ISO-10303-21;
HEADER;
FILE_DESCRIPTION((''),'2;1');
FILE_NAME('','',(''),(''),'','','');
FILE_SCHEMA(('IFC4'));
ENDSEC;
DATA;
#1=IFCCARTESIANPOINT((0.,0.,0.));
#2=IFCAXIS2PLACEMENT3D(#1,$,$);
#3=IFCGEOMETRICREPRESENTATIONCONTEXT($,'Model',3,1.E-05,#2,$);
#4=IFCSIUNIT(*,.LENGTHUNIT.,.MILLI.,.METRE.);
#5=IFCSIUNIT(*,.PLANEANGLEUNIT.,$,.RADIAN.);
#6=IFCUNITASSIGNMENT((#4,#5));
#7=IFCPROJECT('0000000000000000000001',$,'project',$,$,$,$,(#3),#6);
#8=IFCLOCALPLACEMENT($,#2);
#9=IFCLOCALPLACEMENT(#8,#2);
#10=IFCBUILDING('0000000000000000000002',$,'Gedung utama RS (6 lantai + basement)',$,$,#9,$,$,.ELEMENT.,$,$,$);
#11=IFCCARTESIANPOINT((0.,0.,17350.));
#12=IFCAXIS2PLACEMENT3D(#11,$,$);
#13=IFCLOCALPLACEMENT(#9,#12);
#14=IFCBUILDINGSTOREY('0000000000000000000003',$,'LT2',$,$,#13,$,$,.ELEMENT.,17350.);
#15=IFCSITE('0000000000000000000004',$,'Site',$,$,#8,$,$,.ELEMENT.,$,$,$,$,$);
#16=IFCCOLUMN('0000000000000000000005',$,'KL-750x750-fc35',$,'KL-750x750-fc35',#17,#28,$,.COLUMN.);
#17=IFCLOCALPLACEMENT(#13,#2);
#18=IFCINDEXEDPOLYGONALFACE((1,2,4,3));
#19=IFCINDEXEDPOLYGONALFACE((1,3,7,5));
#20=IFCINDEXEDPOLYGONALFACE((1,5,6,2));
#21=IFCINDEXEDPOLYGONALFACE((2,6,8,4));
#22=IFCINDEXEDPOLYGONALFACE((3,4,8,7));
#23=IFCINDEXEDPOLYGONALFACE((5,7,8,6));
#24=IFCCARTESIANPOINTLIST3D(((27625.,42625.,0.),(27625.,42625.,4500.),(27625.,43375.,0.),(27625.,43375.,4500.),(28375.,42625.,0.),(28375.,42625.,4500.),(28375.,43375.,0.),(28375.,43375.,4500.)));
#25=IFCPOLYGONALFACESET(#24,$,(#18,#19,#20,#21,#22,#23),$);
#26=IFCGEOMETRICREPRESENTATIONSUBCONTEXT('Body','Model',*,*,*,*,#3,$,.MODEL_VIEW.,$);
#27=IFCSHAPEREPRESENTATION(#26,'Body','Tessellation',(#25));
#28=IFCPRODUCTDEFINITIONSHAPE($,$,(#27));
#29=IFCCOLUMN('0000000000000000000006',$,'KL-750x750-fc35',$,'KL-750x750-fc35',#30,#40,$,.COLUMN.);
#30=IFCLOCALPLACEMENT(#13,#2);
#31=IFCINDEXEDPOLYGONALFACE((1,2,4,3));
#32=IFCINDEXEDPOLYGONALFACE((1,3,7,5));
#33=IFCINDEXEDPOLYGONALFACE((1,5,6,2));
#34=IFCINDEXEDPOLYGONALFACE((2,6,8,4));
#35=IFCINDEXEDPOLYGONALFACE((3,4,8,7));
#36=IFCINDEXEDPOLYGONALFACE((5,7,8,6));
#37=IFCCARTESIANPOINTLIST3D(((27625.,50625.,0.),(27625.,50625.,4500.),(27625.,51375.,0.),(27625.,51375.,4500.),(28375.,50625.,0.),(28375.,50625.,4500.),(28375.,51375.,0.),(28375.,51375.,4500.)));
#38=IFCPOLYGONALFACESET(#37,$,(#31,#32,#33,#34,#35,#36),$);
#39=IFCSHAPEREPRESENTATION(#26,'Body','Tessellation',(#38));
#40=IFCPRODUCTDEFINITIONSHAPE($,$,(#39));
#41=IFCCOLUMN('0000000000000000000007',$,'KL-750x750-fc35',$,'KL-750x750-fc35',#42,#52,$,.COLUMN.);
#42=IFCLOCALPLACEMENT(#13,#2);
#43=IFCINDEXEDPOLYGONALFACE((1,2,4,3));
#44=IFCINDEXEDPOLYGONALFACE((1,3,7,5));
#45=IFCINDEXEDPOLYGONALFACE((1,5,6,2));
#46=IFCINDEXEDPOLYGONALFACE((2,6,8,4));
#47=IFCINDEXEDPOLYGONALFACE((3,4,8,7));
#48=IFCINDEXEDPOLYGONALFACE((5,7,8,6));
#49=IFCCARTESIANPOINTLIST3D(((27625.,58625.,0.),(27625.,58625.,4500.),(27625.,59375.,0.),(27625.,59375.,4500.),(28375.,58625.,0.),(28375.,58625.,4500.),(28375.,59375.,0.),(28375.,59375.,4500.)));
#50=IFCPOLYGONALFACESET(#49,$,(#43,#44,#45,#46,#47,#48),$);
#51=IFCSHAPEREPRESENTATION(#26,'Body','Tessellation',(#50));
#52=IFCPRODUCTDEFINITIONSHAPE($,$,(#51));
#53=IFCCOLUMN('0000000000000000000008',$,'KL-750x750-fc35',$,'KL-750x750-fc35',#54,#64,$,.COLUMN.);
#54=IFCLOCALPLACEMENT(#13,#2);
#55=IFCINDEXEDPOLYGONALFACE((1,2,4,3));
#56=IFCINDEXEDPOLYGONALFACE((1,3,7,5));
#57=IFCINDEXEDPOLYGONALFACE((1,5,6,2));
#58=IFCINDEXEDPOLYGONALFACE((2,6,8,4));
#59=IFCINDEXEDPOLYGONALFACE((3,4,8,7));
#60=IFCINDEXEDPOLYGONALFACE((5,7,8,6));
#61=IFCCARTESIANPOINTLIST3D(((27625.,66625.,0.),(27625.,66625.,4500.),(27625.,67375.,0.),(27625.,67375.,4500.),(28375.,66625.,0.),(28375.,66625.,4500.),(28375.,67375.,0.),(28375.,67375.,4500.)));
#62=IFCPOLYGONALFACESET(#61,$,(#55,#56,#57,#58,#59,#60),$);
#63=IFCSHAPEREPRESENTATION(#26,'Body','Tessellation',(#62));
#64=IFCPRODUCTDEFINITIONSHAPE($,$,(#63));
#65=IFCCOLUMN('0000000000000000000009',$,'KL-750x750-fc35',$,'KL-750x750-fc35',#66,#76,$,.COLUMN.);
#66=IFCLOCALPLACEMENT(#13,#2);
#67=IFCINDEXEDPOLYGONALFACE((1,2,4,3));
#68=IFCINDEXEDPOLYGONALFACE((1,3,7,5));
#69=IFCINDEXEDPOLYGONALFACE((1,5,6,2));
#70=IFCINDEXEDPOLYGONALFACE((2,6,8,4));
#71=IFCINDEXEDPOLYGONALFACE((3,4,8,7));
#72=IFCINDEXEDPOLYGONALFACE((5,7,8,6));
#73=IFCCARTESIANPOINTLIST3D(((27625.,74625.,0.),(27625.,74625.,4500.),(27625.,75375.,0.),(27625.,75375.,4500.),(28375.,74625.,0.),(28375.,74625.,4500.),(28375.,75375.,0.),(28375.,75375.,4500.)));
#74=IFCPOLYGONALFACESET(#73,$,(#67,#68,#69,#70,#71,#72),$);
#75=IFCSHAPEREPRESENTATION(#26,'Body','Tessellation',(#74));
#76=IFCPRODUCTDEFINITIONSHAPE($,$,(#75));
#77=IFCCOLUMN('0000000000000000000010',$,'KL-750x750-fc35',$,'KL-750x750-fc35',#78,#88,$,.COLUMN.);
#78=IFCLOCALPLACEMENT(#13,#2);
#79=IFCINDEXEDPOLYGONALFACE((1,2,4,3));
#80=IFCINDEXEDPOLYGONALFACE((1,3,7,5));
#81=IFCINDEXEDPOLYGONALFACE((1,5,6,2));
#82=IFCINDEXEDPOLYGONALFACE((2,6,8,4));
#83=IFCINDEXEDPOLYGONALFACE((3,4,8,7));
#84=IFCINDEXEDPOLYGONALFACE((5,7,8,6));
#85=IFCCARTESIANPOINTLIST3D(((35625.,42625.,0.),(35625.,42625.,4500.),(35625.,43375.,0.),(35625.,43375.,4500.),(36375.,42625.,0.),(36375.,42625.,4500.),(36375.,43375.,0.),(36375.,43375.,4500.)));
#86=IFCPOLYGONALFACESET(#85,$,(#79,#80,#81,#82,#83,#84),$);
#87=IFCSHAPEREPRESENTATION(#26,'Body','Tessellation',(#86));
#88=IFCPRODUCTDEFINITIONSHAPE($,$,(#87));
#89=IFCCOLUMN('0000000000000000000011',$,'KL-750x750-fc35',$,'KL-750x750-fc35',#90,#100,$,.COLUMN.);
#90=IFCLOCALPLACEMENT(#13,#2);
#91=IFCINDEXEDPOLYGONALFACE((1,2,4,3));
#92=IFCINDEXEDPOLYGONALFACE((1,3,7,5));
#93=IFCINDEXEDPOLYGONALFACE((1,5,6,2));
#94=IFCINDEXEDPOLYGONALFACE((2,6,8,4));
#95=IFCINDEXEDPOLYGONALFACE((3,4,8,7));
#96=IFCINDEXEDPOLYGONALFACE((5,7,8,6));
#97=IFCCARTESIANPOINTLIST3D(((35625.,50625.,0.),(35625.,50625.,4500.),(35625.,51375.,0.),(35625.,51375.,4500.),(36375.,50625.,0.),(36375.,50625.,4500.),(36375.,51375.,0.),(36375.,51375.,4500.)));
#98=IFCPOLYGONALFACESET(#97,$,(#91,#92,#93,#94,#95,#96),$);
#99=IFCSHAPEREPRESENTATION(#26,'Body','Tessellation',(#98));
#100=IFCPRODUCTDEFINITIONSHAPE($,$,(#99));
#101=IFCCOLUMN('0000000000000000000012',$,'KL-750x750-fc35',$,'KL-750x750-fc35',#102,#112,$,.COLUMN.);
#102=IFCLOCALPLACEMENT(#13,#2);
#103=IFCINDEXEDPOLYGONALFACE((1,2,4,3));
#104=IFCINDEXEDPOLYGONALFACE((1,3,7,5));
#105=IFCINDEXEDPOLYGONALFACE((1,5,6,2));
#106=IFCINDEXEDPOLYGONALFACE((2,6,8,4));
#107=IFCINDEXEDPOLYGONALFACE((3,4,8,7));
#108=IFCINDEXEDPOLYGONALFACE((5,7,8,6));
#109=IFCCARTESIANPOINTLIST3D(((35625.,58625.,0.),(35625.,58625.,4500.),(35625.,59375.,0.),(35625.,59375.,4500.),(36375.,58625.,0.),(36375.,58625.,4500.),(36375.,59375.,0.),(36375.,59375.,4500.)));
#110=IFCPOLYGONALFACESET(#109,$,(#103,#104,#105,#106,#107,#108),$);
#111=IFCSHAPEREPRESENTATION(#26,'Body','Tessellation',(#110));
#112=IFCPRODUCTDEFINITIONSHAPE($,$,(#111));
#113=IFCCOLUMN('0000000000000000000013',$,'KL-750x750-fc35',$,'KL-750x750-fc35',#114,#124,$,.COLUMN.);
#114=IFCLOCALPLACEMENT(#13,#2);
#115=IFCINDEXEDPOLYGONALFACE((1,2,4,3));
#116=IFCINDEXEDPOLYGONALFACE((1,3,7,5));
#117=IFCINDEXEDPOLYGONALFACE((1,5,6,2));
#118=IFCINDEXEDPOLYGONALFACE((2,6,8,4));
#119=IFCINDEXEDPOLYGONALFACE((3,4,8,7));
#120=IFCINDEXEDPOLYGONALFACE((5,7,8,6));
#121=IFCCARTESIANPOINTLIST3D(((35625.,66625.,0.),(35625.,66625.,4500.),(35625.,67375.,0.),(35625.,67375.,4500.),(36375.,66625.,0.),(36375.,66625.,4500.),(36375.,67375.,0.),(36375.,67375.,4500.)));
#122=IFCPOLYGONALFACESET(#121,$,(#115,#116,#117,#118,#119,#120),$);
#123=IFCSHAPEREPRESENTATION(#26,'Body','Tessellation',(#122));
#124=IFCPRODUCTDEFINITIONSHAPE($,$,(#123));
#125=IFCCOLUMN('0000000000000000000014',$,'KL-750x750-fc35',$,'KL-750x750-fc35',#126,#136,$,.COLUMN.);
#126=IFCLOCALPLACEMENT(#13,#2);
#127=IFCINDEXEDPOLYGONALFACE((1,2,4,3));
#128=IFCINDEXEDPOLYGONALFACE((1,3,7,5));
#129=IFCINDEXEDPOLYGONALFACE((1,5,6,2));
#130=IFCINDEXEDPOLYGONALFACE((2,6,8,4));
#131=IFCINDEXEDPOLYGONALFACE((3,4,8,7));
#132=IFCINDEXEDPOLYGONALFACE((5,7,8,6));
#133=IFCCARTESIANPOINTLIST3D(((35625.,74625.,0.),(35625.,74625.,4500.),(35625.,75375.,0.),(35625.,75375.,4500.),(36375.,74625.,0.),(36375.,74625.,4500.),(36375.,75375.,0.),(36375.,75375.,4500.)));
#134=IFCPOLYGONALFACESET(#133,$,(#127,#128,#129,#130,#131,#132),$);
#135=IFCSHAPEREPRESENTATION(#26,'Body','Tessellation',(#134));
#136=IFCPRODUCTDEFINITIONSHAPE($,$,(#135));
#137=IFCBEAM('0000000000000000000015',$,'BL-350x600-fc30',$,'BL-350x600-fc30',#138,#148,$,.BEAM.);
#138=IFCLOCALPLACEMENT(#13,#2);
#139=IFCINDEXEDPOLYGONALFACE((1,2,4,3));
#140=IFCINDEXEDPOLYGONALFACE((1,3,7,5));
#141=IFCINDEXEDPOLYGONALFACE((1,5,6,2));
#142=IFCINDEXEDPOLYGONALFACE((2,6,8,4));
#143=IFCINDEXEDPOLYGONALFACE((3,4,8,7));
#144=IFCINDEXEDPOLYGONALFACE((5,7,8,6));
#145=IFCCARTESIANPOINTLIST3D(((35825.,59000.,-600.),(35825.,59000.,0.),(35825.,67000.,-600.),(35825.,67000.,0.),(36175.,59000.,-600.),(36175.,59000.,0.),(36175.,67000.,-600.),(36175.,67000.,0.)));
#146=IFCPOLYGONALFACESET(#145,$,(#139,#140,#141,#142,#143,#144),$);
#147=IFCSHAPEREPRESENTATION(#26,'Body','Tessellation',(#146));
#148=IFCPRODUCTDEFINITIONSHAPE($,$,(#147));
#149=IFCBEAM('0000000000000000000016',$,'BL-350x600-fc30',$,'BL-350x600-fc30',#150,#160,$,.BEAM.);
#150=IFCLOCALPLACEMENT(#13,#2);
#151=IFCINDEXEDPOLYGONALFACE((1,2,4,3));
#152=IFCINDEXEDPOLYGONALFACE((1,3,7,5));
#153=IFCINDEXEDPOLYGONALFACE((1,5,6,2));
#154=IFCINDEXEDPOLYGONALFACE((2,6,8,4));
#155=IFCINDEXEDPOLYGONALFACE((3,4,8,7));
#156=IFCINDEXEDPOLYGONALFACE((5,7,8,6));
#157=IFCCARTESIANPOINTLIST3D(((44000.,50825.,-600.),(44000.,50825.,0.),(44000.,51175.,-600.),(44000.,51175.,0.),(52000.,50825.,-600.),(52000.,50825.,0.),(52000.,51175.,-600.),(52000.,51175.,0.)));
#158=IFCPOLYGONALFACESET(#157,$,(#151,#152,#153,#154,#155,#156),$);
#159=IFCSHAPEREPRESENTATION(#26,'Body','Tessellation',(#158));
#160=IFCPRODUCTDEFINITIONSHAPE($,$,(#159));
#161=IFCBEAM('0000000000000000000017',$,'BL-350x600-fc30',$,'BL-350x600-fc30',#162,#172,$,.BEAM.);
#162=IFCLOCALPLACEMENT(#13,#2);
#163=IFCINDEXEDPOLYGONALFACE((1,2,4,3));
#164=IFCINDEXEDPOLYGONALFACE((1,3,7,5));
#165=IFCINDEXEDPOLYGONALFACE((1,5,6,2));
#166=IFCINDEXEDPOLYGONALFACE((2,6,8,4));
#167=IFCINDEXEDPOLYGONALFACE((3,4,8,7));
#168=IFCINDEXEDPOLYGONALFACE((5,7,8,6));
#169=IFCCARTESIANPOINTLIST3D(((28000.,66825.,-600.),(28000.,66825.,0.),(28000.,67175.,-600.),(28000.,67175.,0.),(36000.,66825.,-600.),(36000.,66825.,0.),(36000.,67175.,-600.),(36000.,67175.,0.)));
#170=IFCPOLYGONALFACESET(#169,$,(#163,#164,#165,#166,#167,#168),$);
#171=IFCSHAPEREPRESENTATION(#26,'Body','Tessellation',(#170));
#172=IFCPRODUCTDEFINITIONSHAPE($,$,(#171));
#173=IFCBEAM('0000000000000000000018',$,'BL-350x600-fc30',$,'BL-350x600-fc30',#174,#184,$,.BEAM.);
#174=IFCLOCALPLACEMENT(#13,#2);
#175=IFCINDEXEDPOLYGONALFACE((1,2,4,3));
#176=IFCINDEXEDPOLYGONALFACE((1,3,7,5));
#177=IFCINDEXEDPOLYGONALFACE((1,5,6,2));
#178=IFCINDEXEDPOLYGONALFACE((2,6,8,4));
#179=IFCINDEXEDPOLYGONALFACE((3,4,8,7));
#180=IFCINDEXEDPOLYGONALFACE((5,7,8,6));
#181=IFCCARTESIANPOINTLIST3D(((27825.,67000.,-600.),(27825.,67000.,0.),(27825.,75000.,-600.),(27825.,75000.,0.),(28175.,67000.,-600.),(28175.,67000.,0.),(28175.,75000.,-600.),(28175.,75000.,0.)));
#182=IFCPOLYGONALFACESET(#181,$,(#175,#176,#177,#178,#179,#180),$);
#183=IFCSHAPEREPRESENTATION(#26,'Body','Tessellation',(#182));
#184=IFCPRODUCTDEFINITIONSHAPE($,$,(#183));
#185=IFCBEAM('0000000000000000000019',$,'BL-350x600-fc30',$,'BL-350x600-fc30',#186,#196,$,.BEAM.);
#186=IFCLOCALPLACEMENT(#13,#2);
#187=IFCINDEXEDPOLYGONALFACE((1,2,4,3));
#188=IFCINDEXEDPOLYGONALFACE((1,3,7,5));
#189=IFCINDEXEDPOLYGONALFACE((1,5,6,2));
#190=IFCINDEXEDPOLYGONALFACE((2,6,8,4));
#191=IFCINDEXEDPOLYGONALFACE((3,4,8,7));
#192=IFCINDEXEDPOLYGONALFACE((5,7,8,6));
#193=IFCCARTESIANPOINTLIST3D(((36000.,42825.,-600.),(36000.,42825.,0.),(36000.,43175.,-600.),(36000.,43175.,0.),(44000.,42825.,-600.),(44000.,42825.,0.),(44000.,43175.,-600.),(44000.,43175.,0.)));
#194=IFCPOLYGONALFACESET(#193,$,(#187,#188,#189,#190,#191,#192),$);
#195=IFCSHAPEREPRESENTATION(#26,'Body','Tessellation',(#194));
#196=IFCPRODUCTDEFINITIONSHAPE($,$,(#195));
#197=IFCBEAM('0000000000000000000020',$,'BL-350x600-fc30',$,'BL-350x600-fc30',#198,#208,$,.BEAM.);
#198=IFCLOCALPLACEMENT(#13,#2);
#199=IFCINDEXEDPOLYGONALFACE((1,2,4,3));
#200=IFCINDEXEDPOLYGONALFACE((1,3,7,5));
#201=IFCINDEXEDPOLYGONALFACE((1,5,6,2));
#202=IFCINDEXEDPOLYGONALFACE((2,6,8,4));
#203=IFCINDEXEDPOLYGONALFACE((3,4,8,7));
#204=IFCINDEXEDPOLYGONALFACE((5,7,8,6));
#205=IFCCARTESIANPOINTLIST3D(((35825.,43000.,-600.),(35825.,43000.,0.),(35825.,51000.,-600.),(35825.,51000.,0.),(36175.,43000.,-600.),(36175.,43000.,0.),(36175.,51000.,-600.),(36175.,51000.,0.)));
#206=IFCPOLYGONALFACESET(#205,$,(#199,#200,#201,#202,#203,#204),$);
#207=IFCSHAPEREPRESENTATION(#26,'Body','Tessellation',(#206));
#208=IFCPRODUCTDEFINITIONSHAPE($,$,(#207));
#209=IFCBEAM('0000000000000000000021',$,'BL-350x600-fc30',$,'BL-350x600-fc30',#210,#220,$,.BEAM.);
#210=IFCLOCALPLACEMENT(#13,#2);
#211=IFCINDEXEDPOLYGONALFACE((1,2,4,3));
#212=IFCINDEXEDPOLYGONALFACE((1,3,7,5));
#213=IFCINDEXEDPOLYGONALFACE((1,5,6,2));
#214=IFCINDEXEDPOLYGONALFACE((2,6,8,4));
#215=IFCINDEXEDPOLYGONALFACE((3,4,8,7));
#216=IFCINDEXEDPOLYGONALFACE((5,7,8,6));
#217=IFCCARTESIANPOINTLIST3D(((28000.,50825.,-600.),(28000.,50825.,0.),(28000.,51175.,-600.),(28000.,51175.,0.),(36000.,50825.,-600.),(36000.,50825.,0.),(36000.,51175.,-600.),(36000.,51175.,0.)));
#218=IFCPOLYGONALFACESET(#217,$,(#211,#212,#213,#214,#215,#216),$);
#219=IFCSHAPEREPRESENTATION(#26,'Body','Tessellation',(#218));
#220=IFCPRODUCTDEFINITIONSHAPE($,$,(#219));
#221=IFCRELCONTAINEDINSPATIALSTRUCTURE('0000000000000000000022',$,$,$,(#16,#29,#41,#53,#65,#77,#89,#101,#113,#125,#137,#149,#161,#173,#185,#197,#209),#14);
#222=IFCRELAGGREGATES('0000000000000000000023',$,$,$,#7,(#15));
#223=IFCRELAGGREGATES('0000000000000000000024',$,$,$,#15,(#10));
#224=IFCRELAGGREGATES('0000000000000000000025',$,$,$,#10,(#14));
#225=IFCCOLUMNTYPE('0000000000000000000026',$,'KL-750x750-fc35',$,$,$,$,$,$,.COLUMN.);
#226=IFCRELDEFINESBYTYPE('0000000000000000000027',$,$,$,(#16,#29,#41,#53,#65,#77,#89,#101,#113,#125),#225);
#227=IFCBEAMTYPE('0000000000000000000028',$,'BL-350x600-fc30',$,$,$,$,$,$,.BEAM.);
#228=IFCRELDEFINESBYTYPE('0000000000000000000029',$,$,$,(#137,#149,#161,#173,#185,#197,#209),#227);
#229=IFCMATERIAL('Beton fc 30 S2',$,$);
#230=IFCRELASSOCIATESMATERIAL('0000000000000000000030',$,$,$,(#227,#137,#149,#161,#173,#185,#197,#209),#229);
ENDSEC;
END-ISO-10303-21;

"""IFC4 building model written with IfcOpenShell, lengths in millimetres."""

from ifc_helpers import new_model, si_unit, frame, origin, origin_2d, place, context, subcontext, project, spatial, rectangle, extrude, material, material_profile, profile_set, profile_usage, type_object, element, save


model = new_model("IFC4")

# Units and contexts
model_context = context("Model", 3, precision=1e-05, world=origin())
body_context = subcontext(model_context, "Body", "Model", "MODEL_VIEW")
ifc_project = project(units=[si_unit("LENGTHUNIT", "METRE", prefix="MILLI"), si_unit("PLANEANGLEUNIT", "RADIAN")], contexts=[model_context])

# Site, building, storey
site_placement = place(None, origin())
site = spatial("IfcSite", under=ifc_project, at=site_placement, Name="Site", CompositionType="ELEMENT")
building_placement = place(site_placement, origin())
building = spatial("IfcBuilding", under=site, at=building_placement, Name="Gedung utama RS (6 lantai + basement)", CompositionType="ELEMENT")
storey_placement = place(building_placement, frame((0.0, 0.0, 17350.0)))
storey = spatial("IfcBuildingStorey", under=building, at=storey_placement, Name="LT2", CompositionType="ELEMENT", Elevation=17350.0)

# Columns
ifc_material_profile_1 = material_profile(None, rectangle(XDim=750.0, YDim=750.0, at=origin_2d()), Name="KL-750x750-fc35")
ifc_profile_set_1 = profile_set([ifc_material_profile_1], Name="KL-750x750-fc35")
ifc_profile_usage_1 = profile_usage(ifc_profile_set_1, cardinal=5)
column_type = type_object("IfcColumnType", Name="KL-750x750-fc35", PredefinedType="COLUMN", material=ifc_profile_set_1)
for number, where, z_axis, x_axis, name in (
    (1, (28000.0, 43000.0, 0.0), (0.0, 0.0, 1.0), (1.0, 0.0, 0.0), "KL-750x750-fc35"),
    (2, (28000.0, 51000.0, 0.0), (0.0, 0.0, 1.0), (1.0, 0.0, 0.0), "KL-750x750-fc35"),
    (3, (28000.0, 59000.0, 0.0), (0.0, 0.0, 1.0), (1.0, 0.0, 0.0), "KL-750x750-fc35"),
    (4, (28000.0, 67000.0, 0.0), (0.0, 0.0, 1.0), (1.0, 0.0, 0.0), "KL-750x750-fc35"),
    (5, (28000.0, 75000.0, 0.0), (0.0, 0.0, 1.0), (1.0, 0.0, 0.0), "KL-750x750-fc35"),
    (6, (36000.0, 43000.0, 0.0), (0.0, 0.0, 1.0), (1.0, 0.0, 0.0), "KL-750x750-fc35"),
    (7, (36000.0, 51000.0, 0.0), (0.0, 0.0, 1.0), (1.0, 0.0, 0.0), "KL-750x750-fc35"),
    (8, (36000.0, 59000.0, 0.0), (0.0, 0.0, 1.0), (1.0, 0.0, 0.0), "KL-750x750-fc35"),
    (9, (36000.0, 67000.0, 0.0), (0.0, 0.0, 1.0), (1.0, 0.0, 0.0), "KL-750x750-fc35"),
    (10, (36000.0, 75000.0, 0.0), (0.0, 0.0, 1.0), (1.0, 0.0, 0.0), "KL-750x750-fc35"),
):
    element("IfcColumn", number, at=place(storey_placement, frame(where, z_axis=z_axis, x_axis=x_axis)), inside=storey, type_object=column_type, material=ifc_profile_usage_1, Name=name, ObjectType="KL-750x750-fc35", PredefinedType="COLUMN", context=body_context, shape_type="SweptSolid", body=[
        extrude(rectangle(XDim=750.0, YDim=750.0, at=origin_2d()), origin(), (0.0, 0.0, 1.0), 4500.0),
    ])

# Beams
ifc_material = material(Name="Beton fc 30 S2")
ifc_material_profile_2 = material_profile(ifc_material, rectangle(XDim=350.0, YDim=600.0, at=origin_2d()), Name="BL-350x600-fc30")
ifc_profile_set_2 = profile_set([ifc_material_profile_2], Name="BL-350x600-fc30")
ifc_profile_usage_2 = profile_usage(ifc_profile_set_2, cardinal=8)
beam_type = type_object("IfcBeamType", Name="BL-350x600-fc30", PredefinedType="BEAM", material=ifc_profile_set_2)
beam_1_placement = place(storey_placement, frame((36000.0, 59000.0, -300.0)))
element("IfcBeam", 11, at=beam_1_placement, inside=storey, type_object=beam_type, material=ifc_profile_usage_2, Name="BL-350x600-fc30", ObjectType="BL-350x600-fc30", PredefinedType="BEAM", context=body_context, shape_type="SweptSolid", body=[
    extrude(rectangle(XDim=350.0, YDim=600.0, at=origin_2d()), frame((0.0, 0.0, 0.0), z_axis=(0.0, 1.0, 0.0), x_axis=(-1.0, 0.0, 0.0)), (0.0, 0.0, 1.0), 8000.0),
])
for number, where, name in (
    (12, (44000.0, 51000.0, -300.0), "BL-350x600-fc30"),
    (13, (28000.0, 67000.0, -300.0), "BL-350x600-fc30"),
):
    element("IfcBeam", number, at=place(storey_placement, frame(where)), inside=storey, type_object=beam_type, material=ifc_profile_usage_2, Name=name, ObjectType="BL-350x600-fc30", PredefinedType="BEAM", context=body_context, shape_type="SweptSolid", body=[
        extrude(rectangle(XDim=350.0, YDim=600.0, at=origin_2d()), frame((0.0, 0.0, 0.0), z_axis=(1.0, 0.0, 0.0), x_axis=(0.0, 1.0, 0.0)), (0.0, 0.0, 1.0), 8000.0),
    ])
beam_2_placement = place(storey_placement, frame((28000.0, 67000.0, -300.0)))
element("IfcBeam", 14, at=beam_2_placement, inside=storey, type_object=beam_type, material=ifc_profile_usage_2, Name="BL-350x600-fc30", ObjectType="BL-350x600-fc30", PredefinedType="BEAM", context=body_context, shape_type="SweptSolid", body=[
    extrude(rectangle(XDim=350.0, YDim=600.0, at=origin_2d()), frame((0.0, 0.0, 0.0), z_axis=(0.0, 1.0, 0.0), x_axis=(-1.0, 0.0, 0.0)), (0.0, 0.0, 1.0), 8000.0),
])
beam_3_placement = place(storey_placement, frame((36000.0, 43000.0, -300.0)))
element("IfcBeam", 15, at=beam_3_placement, inside=storey, type_object=beam_type, material=ifc_profile_usage_2, Name="BL-350x600-fc30", ObjectType="BL-350x600-fc30", PredefinedType="BEAM", context=body_context, shape_type="SweptSolid", body=[
    extrude(rectangle(XDim=350.0, YDim=600.0, at=origin_2d()), frame((0.0, 0.0, 0.0), z_axis=(1.0, 0.0, 0.0), x_axis=(0.0, 1.0, 0.0)), (0.0, 0.0, 1.0), 8000.0),
])
beam_4_placement = place(storey_placement, frame((36000.0, 43000.0, -300.0)))
element("IfcBeam", 16, at=beam_4_placement, inside=storey, type_object=beam_type, material=ifc_profile_usage_2, Name="BL-350x600-fc30", ObjectType="BL-350x600-fc30", PredefinedType="BEAM", context=body_context, shape_type="SweptSolid", body=[
    extrude(rectangle(XDim=350.0, YDim=600.0, at=origin_2d()), frame((0.0, 0.0, 0.0), z_axis=(0.0, 1.0, 0.0), x_axis=(-1.0, 0.0, 0.0)), (0.0, 0.0, 1.0), 8000.0),
])
beam_5_placement = place(storey_placement, frame((28000.0, 51000.0, -300.0)))
element("IfcBeam", 17, at=beam_5_placement, inside=storey, type_object=beam_type, material=ifc_profile_usage_2, Name="BL-350x600-fc30", ObjectType="BL-350x600-fc30", PredefinedType="BEAM", context=body_context, shape_type="SweptSolid", body=[
    extrude(rectangle(XDim=350.0, YDim=600.0, at=origin_2d()), frame((0.0, 0.0, 0.0), z_axis=(1.0, 0.0, 0.0), x_axis=(0.0, 1.0, 0.0)), (0.0, 0.0, 1.0), 8000.0),
])

save(model, "model.ifc")
